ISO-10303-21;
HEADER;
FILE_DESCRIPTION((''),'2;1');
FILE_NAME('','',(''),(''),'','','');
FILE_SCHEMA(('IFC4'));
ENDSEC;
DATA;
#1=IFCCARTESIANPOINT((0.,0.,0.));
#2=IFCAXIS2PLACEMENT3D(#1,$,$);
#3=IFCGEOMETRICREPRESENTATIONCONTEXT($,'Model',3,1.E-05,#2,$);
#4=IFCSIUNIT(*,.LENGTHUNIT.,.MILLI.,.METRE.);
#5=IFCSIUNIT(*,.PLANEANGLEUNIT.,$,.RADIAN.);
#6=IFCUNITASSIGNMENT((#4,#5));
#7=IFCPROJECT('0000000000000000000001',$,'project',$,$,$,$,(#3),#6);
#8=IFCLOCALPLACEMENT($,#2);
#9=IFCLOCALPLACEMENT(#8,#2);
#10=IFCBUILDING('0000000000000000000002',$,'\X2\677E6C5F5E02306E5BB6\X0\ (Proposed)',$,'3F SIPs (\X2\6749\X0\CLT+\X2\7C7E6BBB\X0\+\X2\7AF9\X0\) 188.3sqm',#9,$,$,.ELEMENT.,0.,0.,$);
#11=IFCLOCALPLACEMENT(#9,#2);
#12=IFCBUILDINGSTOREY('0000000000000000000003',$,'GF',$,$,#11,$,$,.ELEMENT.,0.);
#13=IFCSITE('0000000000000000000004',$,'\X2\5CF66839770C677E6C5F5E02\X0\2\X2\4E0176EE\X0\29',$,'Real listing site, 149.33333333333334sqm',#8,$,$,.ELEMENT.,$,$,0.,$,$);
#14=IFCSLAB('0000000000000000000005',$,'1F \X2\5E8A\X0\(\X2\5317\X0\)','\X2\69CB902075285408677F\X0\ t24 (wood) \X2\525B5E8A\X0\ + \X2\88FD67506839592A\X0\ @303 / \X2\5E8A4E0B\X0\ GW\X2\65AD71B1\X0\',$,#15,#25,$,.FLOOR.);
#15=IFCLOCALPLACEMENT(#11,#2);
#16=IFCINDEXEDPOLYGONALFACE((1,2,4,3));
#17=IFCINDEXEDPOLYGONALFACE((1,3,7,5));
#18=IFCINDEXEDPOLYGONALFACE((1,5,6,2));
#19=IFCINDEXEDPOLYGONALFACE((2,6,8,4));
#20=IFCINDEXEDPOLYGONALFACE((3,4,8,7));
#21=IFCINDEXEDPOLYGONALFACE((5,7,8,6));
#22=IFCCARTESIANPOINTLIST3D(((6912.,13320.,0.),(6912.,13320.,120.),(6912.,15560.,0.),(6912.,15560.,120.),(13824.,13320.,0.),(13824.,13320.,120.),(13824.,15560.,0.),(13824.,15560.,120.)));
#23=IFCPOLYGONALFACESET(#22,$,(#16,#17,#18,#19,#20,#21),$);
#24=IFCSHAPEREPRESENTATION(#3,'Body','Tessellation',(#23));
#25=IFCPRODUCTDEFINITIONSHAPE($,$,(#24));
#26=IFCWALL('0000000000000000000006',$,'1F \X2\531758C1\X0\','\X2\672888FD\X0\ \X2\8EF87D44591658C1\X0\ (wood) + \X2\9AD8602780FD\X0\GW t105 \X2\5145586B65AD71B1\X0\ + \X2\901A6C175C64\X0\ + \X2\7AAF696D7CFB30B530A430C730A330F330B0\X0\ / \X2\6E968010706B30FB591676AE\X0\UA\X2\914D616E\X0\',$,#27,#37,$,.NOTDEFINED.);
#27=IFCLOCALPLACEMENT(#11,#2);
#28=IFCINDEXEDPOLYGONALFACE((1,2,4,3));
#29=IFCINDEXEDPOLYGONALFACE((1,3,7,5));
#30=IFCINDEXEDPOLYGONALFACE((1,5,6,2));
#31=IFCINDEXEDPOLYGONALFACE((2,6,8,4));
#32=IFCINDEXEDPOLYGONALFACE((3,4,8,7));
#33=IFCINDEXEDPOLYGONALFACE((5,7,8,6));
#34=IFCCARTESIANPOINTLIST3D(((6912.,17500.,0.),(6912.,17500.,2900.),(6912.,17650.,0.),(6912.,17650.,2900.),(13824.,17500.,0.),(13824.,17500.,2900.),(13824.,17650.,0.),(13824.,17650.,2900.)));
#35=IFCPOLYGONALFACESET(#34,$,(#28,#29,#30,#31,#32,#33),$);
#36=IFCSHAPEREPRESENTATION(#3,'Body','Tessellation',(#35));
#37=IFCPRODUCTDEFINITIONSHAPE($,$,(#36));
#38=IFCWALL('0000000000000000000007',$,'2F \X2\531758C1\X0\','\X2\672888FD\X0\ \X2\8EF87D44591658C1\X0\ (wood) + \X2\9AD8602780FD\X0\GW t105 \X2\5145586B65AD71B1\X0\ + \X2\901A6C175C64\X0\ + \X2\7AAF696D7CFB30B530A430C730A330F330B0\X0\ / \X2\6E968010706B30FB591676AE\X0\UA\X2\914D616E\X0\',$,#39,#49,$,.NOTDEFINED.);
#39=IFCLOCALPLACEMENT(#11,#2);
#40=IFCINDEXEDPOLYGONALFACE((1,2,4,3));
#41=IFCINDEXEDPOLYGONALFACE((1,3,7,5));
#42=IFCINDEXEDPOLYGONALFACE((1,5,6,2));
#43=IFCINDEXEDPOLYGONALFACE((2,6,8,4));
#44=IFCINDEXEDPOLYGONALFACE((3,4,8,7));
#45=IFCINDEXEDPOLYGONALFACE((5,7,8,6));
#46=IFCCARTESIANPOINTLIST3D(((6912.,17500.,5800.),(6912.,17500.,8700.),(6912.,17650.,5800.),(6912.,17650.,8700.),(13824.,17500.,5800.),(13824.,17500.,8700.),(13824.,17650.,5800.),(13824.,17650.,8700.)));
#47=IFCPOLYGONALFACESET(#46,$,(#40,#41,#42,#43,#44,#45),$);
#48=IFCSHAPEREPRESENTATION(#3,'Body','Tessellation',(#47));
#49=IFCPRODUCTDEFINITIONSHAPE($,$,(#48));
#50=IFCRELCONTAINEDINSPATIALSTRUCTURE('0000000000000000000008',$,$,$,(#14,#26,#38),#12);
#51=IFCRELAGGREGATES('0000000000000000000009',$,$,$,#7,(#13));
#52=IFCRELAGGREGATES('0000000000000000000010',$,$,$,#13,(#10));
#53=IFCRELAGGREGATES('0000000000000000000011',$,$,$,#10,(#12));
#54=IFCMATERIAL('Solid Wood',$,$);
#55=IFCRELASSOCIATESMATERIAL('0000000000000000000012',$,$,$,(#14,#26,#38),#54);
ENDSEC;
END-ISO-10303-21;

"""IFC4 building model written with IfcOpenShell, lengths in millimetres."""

from ifc_helpers import new_model, si_unit, frame, frame_2d, origin, place, context, project, spatial, rectangle, extrude, material, element, save


model = new_model("IFC4")

# Units and contexts
model_context = context("Model", 3, precision=1e-05, world=origin())
ifc_project = project(units=[si_unit("LENGTHUNIT", "METRE", prefix="MILLI"), si_unit("PLANEANGLEUNIT", "RADIAN")], contexts=[model_context])

# Site, building, storey
site_placement = place(None, origin())
site = spatial("IfcSite", under=ifc_project, at=site_placement, Name="島根県松江市2丁目29", ObjectType="Real listing site, 149.33333333333334sqm", CompositionType="ELEMENT", RefElevation=0.0)
building_placement = place(site_placement, origin())
building = spatial("IfcBuilding", under=site, at=building_placement, Name="松江市の家 (Proposed)", ObjectType="3F SIPs (杉CLT+籾殻+竹) 188.3sqm", CompositionType="ELEMENT", ElevationOfRefHeight=0.0, ElevationOfTerrain=0.0)
storey_placement = place(building_placement, origin())
storey = spatial("IfcBuildingStorey", under=building, at=storey_placement, Name="GF", CompositionType="ELEMENT", Elevation=0.0)

# Slab
ifc_material_1 = material(Name="Solid Wood")
slab_1_placement = place(storey_placement, frame((3456.0, 6660.0, 0.0)))
element("IfcSlab", 1, at=slab_1_placement, inside=storey, material=ifc_material_1, Name="1F 床(北)", Description="構造用合板 t24 (wood) 剛床 + 製材根太 @303 / 床下 GW断熱", PredefinedType="FLOOR", context=model_context, shape_type="SweptSolid", body=[
    extrude(rectangle(XDim=6912.0, YDim=2240.0, at=frame_2d((3456.0, 1120.0))), frame((3456.0, 6660.0, 0.0)), (0.0, 0.0, 1.0), 120.0),
])

# Wall
wall_1_placement = place(storey_placement, frame((3456.0, 8750.0, 0.0)))
element("IfcWall", 2, at=wall_1_placement, inside=storey, material=ifc_material_1, Name="1F 北壁", Description="木製 軸組外壁 (wood) + 高性能GW t105 充填断熱 + 通気層 + 窯業系サイディング / 準耐火・外皮UA配慮", PredefinedType="NOTDEFINED", context=model_context, shape_type="SweptSolid", body=[
    extrude(rectangle(XDim=6912.0, YDim=150.0, at=frame_2d((3456.0, 75.0))), frame((3456.0, 8750.0, 0.0)), (0.0, 0.0, 1.0), 2900.0),
])

# Wall
wall_2_placement = place(storey_placement, frame((3456.0, 8750.0, 2900.0)))
element("IfcWall", 3, at=wall_2_placement, inside=storey, material=ifc_material_1, Name="2F 北壁", Description="木製 軸組外壁 (wood) + 高性能GW t105 充填断熱 + 通気層 + 窯業系サイディング / 準耐火・外皮UA配慮", PredefinedType="NOTDEFINED", context=model_context, shape_type="SweptSolid", body=[
    extrude(rectangle(XDim=6912.0, YDim=150.0, at=frame_2d((3456.0, 75.0))), frame((3456.0, 8750.0, 2900.0)), (0.0, 0.0, 1.0), 2900.0),
])

save(model, "model.ifc")
